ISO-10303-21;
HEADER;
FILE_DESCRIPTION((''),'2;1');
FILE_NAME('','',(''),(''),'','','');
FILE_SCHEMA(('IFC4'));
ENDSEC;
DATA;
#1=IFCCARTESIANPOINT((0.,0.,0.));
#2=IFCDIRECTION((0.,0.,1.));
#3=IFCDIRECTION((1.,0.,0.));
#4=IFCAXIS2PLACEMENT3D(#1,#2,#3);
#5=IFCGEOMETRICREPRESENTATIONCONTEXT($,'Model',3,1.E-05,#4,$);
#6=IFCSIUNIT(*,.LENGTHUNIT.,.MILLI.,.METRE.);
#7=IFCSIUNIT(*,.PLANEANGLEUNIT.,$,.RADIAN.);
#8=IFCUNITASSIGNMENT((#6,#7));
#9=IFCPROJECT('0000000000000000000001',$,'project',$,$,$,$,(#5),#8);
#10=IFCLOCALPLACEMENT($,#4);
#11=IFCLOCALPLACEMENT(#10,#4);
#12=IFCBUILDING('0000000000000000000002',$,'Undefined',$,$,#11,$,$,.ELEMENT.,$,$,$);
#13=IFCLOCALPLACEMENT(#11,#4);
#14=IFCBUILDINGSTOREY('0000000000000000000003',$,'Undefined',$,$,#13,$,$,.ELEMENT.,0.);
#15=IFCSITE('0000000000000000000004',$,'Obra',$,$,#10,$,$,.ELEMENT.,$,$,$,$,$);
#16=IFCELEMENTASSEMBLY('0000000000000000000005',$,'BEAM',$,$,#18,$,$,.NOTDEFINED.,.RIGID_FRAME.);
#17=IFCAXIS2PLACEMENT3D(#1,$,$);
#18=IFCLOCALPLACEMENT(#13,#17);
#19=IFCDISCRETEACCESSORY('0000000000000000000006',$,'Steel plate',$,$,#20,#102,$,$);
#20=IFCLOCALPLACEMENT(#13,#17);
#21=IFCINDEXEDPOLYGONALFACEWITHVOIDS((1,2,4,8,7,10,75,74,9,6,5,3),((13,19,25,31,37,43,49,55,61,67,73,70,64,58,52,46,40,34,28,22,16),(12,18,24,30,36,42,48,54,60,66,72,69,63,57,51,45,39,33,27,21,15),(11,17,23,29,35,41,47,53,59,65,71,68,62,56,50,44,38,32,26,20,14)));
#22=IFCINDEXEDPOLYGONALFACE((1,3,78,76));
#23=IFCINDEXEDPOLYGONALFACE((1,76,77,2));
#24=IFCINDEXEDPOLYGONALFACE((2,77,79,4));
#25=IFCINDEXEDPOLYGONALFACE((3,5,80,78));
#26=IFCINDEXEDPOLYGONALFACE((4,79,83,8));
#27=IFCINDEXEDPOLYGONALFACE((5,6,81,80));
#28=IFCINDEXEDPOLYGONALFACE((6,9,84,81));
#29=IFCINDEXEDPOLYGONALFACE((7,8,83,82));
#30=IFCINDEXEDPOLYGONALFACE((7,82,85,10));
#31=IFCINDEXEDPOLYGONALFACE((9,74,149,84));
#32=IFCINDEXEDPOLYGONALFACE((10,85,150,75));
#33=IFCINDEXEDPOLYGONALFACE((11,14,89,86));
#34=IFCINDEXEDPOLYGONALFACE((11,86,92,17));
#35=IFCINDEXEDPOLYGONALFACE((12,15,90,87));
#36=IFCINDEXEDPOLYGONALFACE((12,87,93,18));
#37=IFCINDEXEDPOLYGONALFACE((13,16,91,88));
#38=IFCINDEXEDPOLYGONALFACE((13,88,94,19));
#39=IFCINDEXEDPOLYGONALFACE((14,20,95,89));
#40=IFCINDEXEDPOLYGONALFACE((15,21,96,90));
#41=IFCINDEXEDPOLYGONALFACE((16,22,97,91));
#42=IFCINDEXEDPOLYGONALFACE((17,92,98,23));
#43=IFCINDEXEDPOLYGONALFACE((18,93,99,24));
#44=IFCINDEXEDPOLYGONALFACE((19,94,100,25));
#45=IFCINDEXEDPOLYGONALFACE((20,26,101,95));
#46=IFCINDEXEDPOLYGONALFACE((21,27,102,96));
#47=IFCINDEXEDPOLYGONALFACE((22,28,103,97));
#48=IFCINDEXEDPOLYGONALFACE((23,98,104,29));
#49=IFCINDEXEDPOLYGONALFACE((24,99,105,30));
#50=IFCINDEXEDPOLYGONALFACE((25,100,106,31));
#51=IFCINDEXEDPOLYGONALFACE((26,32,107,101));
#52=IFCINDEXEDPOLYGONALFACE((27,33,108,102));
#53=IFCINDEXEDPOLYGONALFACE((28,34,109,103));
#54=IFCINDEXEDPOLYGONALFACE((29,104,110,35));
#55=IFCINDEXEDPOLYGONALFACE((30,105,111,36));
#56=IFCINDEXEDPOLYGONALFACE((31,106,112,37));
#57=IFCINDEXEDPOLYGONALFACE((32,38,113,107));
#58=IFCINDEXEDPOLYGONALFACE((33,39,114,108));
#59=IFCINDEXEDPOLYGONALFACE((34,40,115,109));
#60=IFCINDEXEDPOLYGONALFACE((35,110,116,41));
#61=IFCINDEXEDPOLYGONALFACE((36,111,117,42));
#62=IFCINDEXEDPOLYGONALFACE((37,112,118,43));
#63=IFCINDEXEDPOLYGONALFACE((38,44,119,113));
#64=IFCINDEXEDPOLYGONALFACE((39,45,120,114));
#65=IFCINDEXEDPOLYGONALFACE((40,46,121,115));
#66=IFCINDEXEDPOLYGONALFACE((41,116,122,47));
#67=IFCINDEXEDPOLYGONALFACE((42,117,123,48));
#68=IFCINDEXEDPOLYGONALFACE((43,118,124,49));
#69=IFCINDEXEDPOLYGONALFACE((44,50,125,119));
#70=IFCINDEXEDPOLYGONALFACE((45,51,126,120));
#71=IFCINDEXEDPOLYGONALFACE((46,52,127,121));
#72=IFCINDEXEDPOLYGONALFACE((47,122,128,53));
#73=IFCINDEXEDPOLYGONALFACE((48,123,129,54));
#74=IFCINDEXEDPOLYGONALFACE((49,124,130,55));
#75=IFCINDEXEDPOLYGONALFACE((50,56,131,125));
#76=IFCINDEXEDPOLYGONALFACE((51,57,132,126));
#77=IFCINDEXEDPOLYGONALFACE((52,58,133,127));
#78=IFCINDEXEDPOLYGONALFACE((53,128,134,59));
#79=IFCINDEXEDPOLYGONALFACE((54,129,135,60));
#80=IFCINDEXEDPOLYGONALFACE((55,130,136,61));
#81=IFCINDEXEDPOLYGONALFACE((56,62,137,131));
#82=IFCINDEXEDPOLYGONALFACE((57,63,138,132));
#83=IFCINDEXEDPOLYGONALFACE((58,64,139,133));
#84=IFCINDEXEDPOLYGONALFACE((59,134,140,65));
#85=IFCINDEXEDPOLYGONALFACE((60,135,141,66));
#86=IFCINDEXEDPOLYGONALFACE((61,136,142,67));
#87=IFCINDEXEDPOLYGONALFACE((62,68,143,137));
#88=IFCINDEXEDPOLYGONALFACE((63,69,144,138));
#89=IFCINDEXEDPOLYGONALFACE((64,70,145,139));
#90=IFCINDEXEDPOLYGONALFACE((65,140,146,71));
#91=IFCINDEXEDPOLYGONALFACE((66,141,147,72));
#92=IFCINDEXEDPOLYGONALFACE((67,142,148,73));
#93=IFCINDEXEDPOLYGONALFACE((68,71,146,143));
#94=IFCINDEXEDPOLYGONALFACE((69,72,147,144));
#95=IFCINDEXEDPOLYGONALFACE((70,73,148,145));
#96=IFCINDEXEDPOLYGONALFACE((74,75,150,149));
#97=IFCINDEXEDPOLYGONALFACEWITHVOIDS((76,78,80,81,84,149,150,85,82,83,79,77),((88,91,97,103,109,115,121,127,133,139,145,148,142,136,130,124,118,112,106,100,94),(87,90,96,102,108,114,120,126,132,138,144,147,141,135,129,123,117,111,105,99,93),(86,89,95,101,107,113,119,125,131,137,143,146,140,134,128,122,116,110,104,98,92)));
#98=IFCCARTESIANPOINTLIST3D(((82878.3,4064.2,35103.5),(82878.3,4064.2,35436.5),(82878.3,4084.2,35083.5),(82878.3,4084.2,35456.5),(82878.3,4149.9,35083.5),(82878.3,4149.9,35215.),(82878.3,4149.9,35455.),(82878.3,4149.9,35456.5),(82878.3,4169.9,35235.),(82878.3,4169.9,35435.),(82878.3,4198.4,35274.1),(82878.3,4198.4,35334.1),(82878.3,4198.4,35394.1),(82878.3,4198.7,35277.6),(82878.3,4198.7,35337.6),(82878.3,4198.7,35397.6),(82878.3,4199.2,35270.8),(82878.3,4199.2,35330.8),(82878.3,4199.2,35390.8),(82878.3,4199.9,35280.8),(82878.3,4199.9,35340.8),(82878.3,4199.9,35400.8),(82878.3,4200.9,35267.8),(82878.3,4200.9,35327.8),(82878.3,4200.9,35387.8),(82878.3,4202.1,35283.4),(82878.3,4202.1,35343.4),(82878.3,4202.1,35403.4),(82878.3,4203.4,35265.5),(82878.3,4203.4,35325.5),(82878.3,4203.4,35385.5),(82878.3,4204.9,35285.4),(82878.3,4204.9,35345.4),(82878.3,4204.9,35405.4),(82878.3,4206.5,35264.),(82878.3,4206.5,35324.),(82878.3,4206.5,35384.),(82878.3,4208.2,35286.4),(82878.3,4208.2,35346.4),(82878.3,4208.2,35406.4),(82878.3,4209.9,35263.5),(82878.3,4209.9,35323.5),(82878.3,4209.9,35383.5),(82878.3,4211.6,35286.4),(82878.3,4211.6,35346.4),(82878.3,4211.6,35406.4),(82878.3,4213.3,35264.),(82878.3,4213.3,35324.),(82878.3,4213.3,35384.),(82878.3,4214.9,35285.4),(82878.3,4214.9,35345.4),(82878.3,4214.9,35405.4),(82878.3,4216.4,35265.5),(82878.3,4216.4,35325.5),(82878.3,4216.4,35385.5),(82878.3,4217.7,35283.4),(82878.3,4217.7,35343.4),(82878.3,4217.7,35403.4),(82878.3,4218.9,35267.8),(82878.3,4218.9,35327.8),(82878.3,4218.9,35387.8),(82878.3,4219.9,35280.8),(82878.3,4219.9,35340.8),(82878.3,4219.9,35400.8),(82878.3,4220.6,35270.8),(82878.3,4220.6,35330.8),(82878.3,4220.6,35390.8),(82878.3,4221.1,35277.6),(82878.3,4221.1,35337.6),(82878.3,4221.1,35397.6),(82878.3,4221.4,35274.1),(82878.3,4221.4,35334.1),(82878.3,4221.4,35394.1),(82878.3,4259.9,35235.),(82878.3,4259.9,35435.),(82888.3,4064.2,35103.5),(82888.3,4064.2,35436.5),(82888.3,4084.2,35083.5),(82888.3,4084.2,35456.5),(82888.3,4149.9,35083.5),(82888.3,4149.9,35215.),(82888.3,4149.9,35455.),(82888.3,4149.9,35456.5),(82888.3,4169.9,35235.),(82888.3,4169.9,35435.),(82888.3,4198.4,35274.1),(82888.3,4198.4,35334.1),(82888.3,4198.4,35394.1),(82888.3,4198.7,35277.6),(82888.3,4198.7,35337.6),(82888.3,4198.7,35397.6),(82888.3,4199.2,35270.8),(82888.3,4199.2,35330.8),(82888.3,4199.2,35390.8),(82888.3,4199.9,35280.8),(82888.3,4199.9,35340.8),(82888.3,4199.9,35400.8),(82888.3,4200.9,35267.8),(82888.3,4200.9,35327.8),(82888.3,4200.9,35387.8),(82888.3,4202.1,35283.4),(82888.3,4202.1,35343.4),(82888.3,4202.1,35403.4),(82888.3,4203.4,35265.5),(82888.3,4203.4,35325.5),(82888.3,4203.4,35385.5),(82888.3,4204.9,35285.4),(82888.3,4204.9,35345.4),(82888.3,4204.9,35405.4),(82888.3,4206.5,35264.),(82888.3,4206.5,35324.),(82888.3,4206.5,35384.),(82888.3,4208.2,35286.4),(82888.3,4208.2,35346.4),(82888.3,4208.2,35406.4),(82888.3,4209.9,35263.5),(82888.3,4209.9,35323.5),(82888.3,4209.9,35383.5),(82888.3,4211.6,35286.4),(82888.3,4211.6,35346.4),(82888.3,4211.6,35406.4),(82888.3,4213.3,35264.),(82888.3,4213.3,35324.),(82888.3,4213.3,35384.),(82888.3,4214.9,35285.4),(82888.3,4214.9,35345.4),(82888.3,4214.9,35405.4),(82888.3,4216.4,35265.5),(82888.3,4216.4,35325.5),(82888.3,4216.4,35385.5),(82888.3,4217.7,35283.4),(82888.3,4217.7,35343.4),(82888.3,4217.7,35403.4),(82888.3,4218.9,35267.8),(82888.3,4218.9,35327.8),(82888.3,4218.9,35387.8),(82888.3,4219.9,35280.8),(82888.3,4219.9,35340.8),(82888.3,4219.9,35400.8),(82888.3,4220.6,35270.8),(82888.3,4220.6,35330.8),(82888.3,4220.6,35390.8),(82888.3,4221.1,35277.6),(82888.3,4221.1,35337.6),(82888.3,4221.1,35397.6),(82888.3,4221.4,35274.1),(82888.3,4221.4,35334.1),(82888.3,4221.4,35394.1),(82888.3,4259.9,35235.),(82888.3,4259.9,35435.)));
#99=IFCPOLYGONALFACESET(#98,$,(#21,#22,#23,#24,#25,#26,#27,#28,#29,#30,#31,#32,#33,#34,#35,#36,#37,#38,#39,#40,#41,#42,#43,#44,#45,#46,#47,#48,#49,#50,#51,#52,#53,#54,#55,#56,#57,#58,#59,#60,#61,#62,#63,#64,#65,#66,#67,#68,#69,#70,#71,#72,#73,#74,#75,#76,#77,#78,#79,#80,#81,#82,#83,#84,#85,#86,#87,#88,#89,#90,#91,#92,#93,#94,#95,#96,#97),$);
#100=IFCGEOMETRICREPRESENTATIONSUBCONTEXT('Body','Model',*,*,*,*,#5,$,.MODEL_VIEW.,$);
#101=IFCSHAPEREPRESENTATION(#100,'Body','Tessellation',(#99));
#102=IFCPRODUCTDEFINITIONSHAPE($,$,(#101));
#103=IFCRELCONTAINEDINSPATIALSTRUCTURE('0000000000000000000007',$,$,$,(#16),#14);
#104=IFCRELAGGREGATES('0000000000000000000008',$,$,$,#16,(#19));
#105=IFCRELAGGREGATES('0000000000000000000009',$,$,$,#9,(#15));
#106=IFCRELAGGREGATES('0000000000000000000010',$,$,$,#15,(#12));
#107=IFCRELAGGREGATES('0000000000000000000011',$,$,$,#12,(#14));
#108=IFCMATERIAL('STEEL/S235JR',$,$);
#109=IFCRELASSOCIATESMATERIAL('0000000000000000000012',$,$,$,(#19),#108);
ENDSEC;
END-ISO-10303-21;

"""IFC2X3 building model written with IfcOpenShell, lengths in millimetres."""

from ifc_helpers import new_model, si_unit, frame, origin_with_axes, origin_2d_with_axis, place, context, subcontext, project, spatial, polyline, circle, outline, extrude, source, transform, mapped, material, element, aggregate, save


model = new_model("IFC2X3")

# Units and contexts
model_context = context("Model", 3, precision=1e-05, world=origin_with_axes())
body_context = subcontext(model_context, "Body", "Model", "MODEL_VIEW")
ifc_project = project(units=[si_unit("LENGTHUNIT", "METRE", prefix="MILLI"), si_unit("PLANEANGLEUNIT", "RADIAN")], contexts=[model_context])

# Site, building, storey
site_placement = place(None, origin_with_axes())
site = spatial("IfcSite", under=ifc_project, at=site_placement, Name="Obra", CompositionType="ELEMENT")
building_placement = place(site_placement, origin_with_axes())
building = spatial("IfcBuilding", under=site, at=building_placement, Name="Undefined", CompositionType="ELEMENT")
storey_placement = place(building_placement, origin_with_axes())
storey = spatial("IfcBuildingStorey", under=building, at=storey_placement, Name="Undefined", CompositionType="ELEMENT", Elevation=0.0)

# Shared definitions
ifc_material_1 = material(Name="STEEL/S235JR")

# Element assembly, discrete accessory, opening
assembly_1_placement = place(storey_placement, origin_with_axes())
assembly_1 = element("IfcElementAssembly", 1, at=assembly_1_placement, inside=storey, Name="BEAM", AssemblyPlace="NOTDEFINED", PredefinedType="RIGID_FRAME")
shared_shape_1 = source(origin_with_axes(), body_context, "Body", "SweptSolid", [
    extrude(circle(Radius=11.5, at=origin_2d_with_axis()), frame((0.0, -13.4, 0.0), z_axis=(0.0, 1.0, 0.0), x_axis=(1.0, 0.0, 0.0)), (0.0, 0.0, 1.0), 10.2),
])
discrete_accessory_1_placement = place(assembly_1_placement, frame((82883.3, 4064.2, 35103.5), z_axis=(1.0, 0.0, 0.0), x_axis=(0.0, 0.707107, -0.707107)))
discrete_accessory_1 = element("IfcDiscreteAccessory", 2, at=discrete_accessory_1_placement, material=ifc_material_1, Name="Steel plate", context=body_context, shape_type="SweptSolid", body=[
    extrude(outline(polyline([(0.0, 0.0), (28.3, 0.0), (74.7, 46.5), (-18.2, 139.4), (-18.2, 167.7), (45.4, 231.4), (-96.0, 372.8), (-159.7, 309.1), (-187.9, 309.1), (-189.0, 310.2), (-235.5, 263.8), (-235.5, 235.5), (0.0, 0.0)])), frame((0.0, 0.0, -5.0), z_axis=(0.0, 0.0, 1.0), x_axis=(1.0, 0.0, 0.0)), (0.0, 0.0, 1.0), 10.0),
])
opening_1_placement = place(assembly_1_placement, frame((82875.0, 4159.9, 35435.0), z_axis=(0.0, 1.0, 0.0), x_axis=(0.0, 0.0, -1.0)))
element("IfcOpeningElement", 3, at=opening_1_placement, cuts=discrete_accessory_1, ObjectType="Opening", context=body_context, shape_type="MappedRepresentation", body=[
    mapped(shared_shape_1, transform((40.0, 0.0, 50.0))),
    mapped(shared_shape_1, transform((100.0, 0.0, 50.0))),
    mapped(shared_shape_1, transform((160.0, 0.0, 50.0))),
])
aggregate(assembly_1, [discrete_accessory_1])

save(model, "model.ifc")
